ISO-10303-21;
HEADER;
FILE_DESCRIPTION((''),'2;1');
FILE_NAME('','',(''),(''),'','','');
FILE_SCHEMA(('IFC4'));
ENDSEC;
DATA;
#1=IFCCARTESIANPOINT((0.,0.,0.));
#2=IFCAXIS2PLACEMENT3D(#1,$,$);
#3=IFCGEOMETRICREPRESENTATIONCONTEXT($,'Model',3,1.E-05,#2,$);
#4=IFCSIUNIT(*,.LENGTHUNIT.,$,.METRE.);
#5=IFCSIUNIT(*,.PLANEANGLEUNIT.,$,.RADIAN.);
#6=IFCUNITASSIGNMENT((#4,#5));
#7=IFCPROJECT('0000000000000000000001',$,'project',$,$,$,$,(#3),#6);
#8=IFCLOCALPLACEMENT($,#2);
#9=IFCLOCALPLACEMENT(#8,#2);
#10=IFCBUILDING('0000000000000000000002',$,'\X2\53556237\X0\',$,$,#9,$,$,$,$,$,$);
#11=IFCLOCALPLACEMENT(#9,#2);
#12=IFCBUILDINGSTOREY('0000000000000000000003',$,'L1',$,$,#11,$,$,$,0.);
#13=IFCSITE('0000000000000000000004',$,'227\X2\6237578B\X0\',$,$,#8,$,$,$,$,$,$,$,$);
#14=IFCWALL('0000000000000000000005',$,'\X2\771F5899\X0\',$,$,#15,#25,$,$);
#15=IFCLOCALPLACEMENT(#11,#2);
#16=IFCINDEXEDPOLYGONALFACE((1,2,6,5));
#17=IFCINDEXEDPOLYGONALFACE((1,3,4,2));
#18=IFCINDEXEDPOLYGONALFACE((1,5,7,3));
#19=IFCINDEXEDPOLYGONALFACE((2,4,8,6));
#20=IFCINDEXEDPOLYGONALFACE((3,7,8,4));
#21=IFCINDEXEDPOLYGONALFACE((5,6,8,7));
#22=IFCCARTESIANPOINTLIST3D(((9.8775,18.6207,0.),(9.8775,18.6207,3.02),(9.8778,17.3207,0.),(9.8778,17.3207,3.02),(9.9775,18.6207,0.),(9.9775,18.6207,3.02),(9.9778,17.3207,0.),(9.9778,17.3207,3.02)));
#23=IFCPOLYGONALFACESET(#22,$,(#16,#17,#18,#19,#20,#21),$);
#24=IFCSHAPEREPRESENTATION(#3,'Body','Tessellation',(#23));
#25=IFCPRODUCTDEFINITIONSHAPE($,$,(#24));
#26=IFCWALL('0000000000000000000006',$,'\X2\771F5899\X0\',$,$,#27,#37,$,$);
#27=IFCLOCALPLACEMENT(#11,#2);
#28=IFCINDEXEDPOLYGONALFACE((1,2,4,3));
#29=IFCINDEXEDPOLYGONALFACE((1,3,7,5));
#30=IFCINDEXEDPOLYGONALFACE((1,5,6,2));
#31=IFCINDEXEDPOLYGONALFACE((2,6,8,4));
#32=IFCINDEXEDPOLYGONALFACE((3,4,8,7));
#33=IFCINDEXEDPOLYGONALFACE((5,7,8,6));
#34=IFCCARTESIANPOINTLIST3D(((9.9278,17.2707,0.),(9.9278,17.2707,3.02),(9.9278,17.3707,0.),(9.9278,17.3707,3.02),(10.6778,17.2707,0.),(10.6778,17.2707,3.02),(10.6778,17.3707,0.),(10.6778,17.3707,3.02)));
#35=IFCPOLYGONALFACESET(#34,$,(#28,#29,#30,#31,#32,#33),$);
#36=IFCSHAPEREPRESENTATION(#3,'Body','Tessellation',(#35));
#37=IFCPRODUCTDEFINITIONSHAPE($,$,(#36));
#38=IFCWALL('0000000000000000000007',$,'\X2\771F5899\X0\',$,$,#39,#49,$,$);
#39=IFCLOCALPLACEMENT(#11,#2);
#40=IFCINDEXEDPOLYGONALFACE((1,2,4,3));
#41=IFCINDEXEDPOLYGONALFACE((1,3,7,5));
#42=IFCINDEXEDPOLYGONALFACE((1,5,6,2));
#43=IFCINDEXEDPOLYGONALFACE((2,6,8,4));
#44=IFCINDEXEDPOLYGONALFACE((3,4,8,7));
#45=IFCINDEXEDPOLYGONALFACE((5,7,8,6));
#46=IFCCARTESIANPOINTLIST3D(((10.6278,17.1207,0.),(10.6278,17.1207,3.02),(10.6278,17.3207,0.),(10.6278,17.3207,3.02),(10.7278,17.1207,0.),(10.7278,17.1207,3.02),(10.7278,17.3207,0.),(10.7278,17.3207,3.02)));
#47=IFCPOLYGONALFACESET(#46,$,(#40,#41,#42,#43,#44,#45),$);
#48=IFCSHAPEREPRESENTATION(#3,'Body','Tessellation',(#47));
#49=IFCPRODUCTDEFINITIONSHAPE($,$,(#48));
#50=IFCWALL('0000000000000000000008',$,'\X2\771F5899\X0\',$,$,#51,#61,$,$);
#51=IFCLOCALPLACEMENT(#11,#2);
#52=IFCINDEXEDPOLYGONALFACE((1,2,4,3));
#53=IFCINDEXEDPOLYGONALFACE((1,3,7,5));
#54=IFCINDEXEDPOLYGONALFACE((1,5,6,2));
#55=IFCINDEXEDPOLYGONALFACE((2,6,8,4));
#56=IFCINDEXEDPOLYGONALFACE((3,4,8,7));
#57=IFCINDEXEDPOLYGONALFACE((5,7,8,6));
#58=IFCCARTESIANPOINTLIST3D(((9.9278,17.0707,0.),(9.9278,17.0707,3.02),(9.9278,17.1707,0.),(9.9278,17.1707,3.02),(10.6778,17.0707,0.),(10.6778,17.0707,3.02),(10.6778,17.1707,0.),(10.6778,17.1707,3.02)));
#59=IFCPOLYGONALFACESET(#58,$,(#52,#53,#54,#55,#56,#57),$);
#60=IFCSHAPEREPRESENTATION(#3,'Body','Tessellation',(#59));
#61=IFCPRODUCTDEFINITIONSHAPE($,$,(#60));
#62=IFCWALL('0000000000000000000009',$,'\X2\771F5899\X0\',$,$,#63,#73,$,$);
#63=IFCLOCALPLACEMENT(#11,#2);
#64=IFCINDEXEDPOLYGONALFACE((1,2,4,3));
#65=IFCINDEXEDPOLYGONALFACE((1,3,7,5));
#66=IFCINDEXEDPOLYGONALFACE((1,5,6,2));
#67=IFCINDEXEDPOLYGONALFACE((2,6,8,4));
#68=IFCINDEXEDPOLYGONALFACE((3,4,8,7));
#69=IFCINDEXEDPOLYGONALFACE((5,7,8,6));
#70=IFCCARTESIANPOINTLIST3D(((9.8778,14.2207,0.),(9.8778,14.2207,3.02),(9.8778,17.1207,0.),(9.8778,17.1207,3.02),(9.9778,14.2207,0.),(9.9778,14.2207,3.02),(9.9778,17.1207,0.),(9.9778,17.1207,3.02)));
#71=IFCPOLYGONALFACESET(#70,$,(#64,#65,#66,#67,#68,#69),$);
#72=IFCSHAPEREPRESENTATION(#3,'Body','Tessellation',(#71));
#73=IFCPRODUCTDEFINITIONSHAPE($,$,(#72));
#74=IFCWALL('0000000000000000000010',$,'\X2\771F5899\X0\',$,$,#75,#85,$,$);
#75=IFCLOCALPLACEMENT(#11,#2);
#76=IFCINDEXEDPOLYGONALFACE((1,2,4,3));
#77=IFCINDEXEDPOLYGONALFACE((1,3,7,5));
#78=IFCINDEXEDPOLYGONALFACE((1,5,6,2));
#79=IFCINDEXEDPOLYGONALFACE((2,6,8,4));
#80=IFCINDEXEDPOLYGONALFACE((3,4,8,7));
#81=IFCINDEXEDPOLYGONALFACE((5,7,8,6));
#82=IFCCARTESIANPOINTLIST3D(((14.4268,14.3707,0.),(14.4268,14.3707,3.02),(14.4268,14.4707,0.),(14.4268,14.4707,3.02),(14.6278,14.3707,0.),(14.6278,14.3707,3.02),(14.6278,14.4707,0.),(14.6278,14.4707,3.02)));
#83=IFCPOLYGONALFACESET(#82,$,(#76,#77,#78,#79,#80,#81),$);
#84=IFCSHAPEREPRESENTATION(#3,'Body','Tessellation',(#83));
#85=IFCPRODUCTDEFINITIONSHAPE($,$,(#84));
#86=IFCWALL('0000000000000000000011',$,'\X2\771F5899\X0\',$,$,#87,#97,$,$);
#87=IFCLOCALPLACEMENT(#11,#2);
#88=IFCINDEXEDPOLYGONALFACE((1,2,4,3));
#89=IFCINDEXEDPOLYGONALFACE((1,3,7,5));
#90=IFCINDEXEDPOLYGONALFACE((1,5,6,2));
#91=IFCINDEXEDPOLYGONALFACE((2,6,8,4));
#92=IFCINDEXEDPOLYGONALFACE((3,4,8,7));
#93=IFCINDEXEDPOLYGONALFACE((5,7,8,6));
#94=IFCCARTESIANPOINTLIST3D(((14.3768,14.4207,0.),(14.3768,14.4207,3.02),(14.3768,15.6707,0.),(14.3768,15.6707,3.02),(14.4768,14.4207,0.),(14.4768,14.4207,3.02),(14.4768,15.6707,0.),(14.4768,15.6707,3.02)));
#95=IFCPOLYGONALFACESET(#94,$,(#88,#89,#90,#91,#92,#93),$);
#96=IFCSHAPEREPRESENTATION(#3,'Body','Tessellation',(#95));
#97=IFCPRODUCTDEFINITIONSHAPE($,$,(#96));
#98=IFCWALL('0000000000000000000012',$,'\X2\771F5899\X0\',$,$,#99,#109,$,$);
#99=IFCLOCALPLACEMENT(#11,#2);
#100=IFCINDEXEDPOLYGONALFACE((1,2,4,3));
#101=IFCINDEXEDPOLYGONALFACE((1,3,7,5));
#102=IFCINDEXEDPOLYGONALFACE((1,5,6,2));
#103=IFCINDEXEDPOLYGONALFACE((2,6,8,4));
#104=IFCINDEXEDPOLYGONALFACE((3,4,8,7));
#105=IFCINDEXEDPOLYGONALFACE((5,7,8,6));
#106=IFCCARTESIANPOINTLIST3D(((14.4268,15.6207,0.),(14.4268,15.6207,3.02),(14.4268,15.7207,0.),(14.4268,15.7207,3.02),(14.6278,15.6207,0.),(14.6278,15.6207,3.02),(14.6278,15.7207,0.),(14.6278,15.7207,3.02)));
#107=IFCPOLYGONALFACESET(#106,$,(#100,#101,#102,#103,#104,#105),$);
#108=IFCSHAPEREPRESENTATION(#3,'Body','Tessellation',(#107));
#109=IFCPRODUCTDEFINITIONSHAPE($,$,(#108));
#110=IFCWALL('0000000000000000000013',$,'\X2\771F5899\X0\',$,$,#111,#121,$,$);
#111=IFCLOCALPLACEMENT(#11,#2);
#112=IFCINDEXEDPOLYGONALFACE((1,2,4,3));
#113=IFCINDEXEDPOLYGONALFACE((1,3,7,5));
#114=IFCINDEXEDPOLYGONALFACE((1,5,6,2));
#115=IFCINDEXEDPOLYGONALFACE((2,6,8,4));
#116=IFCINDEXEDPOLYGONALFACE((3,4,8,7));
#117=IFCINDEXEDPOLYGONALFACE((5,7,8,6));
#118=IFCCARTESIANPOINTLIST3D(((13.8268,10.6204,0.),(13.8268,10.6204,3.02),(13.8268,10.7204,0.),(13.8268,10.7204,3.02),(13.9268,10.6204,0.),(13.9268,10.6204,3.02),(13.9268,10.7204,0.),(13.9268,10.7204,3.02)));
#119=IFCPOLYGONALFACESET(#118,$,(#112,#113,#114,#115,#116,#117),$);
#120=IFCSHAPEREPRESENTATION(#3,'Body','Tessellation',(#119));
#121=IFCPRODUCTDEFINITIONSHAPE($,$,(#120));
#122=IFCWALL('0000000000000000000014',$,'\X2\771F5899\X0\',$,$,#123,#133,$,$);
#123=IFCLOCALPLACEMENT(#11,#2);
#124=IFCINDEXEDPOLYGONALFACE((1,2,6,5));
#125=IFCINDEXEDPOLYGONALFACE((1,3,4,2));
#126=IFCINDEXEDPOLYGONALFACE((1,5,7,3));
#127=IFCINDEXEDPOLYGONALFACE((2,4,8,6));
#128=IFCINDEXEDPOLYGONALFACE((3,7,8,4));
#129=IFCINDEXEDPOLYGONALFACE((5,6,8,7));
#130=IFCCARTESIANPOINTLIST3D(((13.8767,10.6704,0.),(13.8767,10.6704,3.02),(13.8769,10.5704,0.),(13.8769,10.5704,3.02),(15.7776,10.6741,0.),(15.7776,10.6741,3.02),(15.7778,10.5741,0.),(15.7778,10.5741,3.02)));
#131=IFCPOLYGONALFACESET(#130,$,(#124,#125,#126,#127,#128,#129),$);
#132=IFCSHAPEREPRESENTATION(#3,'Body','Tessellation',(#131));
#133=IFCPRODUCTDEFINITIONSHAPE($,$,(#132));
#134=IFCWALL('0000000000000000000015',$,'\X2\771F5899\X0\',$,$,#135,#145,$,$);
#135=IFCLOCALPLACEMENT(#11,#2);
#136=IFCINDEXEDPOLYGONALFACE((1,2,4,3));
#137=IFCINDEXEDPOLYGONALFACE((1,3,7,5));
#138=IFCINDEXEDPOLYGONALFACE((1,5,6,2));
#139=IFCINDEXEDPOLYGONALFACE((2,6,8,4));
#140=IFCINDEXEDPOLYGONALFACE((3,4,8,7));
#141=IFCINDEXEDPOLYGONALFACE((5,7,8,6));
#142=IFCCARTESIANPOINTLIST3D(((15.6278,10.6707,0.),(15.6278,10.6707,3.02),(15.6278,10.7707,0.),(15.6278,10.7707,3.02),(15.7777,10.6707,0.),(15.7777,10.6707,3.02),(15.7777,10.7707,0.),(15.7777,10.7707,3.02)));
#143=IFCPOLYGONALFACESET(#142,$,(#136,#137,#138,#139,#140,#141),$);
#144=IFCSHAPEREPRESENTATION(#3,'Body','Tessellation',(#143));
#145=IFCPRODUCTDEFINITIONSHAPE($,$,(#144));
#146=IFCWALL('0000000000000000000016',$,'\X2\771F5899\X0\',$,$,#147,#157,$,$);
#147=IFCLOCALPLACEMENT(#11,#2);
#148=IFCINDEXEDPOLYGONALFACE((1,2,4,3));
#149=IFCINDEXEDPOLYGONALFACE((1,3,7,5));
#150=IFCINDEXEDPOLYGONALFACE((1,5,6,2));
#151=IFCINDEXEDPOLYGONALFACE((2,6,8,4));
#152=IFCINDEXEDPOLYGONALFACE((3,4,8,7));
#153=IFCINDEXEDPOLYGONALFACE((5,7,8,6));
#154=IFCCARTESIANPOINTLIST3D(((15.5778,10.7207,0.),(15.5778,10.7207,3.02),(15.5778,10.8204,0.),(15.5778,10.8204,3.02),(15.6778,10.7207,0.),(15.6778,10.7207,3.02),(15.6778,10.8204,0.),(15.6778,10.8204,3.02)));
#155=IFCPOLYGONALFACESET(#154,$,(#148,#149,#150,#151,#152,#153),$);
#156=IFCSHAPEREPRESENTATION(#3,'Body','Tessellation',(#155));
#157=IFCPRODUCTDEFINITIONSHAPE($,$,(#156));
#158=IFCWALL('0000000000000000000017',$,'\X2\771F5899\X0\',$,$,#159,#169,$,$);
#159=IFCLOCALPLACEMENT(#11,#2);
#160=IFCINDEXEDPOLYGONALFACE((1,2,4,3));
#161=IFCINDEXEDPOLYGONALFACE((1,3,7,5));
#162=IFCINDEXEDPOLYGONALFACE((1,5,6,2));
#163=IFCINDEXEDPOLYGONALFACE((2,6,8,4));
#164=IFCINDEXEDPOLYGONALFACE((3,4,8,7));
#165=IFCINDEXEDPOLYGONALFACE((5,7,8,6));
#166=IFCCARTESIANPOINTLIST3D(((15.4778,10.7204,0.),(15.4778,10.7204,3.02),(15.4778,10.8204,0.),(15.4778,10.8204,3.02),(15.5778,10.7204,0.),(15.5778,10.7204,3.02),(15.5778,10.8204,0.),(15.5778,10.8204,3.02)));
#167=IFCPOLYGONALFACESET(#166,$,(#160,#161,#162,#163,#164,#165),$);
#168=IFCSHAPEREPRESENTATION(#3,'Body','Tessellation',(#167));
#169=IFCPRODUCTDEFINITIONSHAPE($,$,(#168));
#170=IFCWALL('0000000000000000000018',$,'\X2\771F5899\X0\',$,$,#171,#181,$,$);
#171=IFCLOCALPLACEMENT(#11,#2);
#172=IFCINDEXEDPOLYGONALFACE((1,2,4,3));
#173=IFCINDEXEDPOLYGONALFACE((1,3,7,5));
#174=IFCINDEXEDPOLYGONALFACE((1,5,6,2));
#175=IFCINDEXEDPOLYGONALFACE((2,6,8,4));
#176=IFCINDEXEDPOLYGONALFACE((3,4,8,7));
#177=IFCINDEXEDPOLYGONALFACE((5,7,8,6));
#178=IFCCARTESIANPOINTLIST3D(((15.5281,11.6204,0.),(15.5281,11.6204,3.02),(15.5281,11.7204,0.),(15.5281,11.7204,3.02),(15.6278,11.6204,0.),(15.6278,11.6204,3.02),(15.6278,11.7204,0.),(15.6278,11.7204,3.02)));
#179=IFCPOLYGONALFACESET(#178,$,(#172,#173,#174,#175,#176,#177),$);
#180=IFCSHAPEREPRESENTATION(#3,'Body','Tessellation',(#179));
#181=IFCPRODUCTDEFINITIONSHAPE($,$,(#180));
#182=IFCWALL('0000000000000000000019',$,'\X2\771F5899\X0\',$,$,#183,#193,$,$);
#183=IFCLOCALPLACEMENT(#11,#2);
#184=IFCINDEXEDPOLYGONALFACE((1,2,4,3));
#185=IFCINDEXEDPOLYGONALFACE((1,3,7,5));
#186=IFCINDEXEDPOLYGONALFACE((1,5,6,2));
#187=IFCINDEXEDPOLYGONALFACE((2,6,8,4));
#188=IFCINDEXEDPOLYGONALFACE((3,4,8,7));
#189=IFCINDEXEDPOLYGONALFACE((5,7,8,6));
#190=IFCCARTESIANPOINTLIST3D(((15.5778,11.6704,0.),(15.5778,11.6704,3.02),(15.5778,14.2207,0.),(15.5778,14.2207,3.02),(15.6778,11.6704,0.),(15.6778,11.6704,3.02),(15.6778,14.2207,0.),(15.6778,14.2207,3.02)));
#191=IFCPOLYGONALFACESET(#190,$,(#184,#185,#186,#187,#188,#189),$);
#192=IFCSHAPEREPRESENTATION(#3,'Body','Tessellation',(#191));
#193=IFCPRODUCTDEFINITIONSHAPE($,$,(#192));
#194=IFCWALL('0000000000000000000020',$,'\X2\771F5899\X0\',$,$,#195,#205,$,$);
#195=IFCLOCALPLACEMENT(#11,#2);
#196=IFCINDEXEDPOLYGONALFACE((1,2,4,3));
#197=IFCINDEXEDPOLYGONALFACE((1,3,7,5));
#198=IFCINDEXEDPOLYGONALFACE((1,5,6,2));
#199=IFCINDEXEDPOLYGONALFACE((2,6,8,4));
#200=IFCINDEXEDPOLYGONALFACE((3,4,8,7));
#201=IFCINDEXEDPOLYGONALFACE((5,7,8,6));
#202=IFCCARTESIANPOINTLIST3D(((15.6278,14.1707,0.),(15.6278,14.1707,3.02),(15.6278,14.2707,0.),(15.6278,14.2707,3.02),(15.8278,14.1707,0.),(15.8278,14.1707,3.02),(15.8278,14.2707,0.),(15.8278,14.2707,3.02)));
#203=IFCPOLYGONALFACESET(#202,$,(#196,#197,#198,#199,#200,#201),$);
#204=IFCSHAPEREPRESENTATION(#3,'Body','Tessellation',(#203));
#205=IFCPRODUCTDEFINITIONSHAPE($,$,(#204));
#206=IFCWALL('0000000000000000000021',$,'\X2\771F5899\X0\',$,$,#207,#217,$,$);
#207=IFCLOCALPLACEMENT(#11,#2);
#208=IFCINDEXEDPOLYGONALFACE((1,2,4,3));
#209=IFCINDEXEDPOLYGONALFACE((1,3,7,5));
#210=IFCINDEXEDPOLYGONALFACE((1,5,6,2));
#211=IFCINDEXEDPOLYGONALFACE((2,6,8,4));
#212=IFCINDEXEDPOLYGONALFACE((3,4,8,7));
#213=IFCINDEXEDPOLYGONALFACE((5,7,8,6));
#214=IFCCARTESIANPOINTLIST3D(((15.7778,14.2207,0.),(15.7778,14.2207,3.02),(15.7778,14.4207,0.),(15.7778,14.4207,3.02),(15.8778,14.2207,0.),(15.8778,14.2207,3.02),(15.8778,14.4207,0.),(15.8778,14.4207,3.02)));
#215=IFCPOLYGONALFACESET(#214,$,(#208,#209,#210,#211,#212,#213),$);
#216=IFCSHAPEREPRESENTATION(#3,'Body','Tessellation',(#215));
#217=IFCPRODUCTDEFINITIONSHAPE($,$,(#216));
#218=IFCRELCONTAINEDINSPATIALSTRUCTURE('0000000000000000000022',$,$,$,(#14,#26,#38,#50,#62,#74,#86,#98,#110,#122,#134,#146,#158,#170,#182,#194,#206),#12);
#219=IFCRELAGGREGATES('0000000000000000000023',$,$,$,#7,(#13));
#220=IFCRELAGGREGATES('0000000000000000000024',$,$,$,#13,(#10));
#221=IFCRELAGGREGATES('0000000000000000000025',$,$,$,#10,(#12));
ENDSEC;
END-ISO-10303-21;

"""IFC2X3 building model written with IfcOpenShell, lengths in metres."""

from ifc_helpers import new_model, si_unit, origin, place, context, project, spatial, polyline, outline, extrude, element, save


model = new_model("IFC2X3")

# Units and contexts
model_context = context("Model", 3, precision=1e-05, world=origin())
ifc_project = project(units=[si_unit("LENGTHUNIT", "METRE"), si_unit("PLANEANGLEUNIT", "RADIAN")], contexts=[model_context])

# Site, building, storey
site_placement = place(None, origin())
site = spatial("IfcSite", under=ifc_project, at=site_placement, Name="227户型")
building_placement = place(site_placement, origin())
building = spatial("IfcBuilding", under=site, at=building_placement, Name="单户")
storey_placement = place(building_placement, origin())
storey = spatial("IfcBuildingStorey", under=building, at=storey_placement, Name="L1", Elevation=0.0)

# Walls
wall_1_placement = place(storey_placement, origin())
element("IfcWall", 1, at=wall_1_placement, inside=storey, Name="真墙", context=model_context, shape_type="SweptSolid", body=[
    extrude(outline(polyline([(9.9775, 18.6207), (9.9778, 17.3207), (9.8778, 17.3207), (9.8775, 18.6207), (9.9775, 18.6207)])), origin(), (0.0, 0.0, 1.0), 3.02),
])
wall_2_placement = place(storey_placement, origin())
element("IfcWall", 2, at=wall_2_placement, inside=storey, Name="真墙", context=model_context, shape_type="SweptSolid", body=[
    extrude(outline(polyline([(9.9278, 17.3707), (10.6778, 17.3707), (10.6778, 17.2707), (9.9278, 17.2707), (9.9278, 17.3707)])), origin(), (0.0, 0.0, 1.0), 3.02),
])
wall_3_placement = place(storey_placement, origin())
element("IfcWall", 3, at=wall_3_placement, inside=storey, Name="真墙", context=model_context, shape_type="SweptSolid", body=[
    extrude(outline(polyline([(10.7278, 17.3207), (10.7278, 17.1207), (10.6278, 17.1207), (10.6278, 17.3207), (10.7278, 17.3207)])), origin(), (0.0, 0.0, 1.0), 3.02),
])
wall_4_placement = place(storey_placement, origin())
element("IfcWall", 4, at=wall_4_placement, inside=storey, Name="真墙", context=model_context, shape_type="SweptSolid", body=[
    extrude(outline(polyline([(10.6778, 17.0707), (9.9278, 17.0707), (9.9278, 17.1707), (10.6778, 17.1707), (10.6778, 17.0707)])), origin(), (0.0, 0.0, 1.0), 3.02),
])
wall_5_placement = place(storey_placement, origin())
element("IfcWall", 5, at=wall_5_placement, inside=storey, Name="真墙", context=model_context, shape_type="SweptSolid", body=[
    extrude(outline(polyline([(9.9778, 17.1207), (9.9778, 14.2207), (9.8778, 14.2207), (9.8778, 17.1207), (9.9778, 17.1207)])), origin(), (0.0, 0.0, 1.0), 3.02),
])
wall_6_placement = place(storey_placement, origin())
element("IfcWall", 6, at=wall_6_placement, inside=storey, Name="真墙", context=model_context, shape_type="SweptSolid", body=[
    extrude(outline(polyline([(14.6278, 14.3707), (14.4268, 14.3707), (14.4268, 14.4707), (14.6278, 14.4707), (14.6278, 14.3707)])), origin(), (0.0, 0.0, 1.0), 3.02),
])
wall_7_placement = place(storey_placement, origin())
element("IfcWall", 7, at=wall_7_placement, inside=storey, Name="真墙", context=model_context, shape_type="SweptSolid", body=[
    extrude(outline(polyline([(14.3768, 14.4207), (14.3768, 15.6707), (14.4768, 15.6707), (14.4768, 14.4207), (14.3768, 14.4207)])), origin(), (0.0, 0.0, 1.0), 3.02),
])
wall_8_placement = place(storey_placement, origin())
element("IfcWall", 8, at=wall_8_placement, inside=storey, Name="真墙", context=model_context, shape_type="SweptSolid", body=[
    extrude(outline(polyline([(14.4268, 15.7207), (14.6278, 15.7207), (14.6278, 15.6207), (14.4268, 15.6207), (14.4268, 15.7207)])), origin(), (0.0, 0.0, 1.0), 3.02),
])
wall_9_placement = place(storey_placement, origin())
element("IfcWall", 9, at=wall_9_placement, inside=storey, Name="真墙", context=model_context, shape_type="SweptSolid", body=[
    extrude(outline(polyline([(13.9268, 10.7204), (13.9268, 10.6204), (13.8268, 10.6204), (13.8268, 10.7204), (13.9268, 10.7204)])), origin(), (0.0, 0.0, 1.0), 3.02),
])
wall_10_placement = place(storey_placement, origin())
element("IfcWall", 10, at=wall_10_placement, inside=storey, Name="真墙", context=model_context, shape_type="SweptSolid", body=[
    extrude(outline(polyline([(13.8767, 10.6704), (15.7776, 10.6741), (15.7778, 10.5741), (13.8769, 10.5704), (13.8767, 10.6704)])), origin(), (0.0, 0.0, 1.0), 3.02),
])

# Walls
wall_11_placement = place(storey_placement, origin())
element("IfcWall", 11, at=wall_11_placement, inside=storey, Name="真墙", context=model_context, shape_type="SweptSolid", body=[
    extrude(outline(polyline([(15.7777, 10.6707), (15.6278, 10.6707), (15.6278, 10.7707), (15.7777, 10.7707), (15.7777, 10.6707)])), origin(), (0.0, 0.0, 1.0), 3.02),
])
wall_12_placement = place(storey_placement, origin())
element("IfcWall", 12, at=wall_12_placement, inside=storey, Name="真墙", context=model_context, shape_type="SweptSolid", body=[
    extrude(outline(polyline([(15.5778, 10.7207), (15.5778, 10.8204), (15.6778, 10.8204), (15.6778, 10.7207), (15.5778, 10.7207)])), origin(), (0.0, 0.0, 1.0), 3.02),
])

# Walls
wall_13_placement = place(storey_placement, origin())
element("IfcWall", 13, at=wall_13_placement, inside=storey, Name="真墙", context=model_context, shape_type="SweptSolid", body=[
    extrude(outline(polyline([(15.5778, 10.8204), (15.5778, 10.7204), (15.4778, 10.7204), (15.4778, 10.8204), (15.5778, 10.8204)])), origin(), (0.0, 0.0, 1.0), 3.02),
])
wall_14_placement = place(storey_placement, origin())
element("IfcWall", 14, at=wall_14_placement, inside=storey, Name="真墙", context=model_context, shape_type="SweptSolid", body=[
    extrude(outline(polyline([(15.5281, 11.7204), (15.6278, 11.7204), (15.6278, 11.6204), (15.5281, 11.6204), (15.5281, 11.7204)])), origin(), (0.0, 0.0, 1.0), 3.02),
])
wall_15_placement = place(storey_placement, origin())
element("IfcWall", 15, at=wall_15_placement, inside=storey, Name="真墙", context=model_context, shape_type="SweptSolid", body=[
    extrude(outline(polyline([(15.5778, 11.6704), (15.5778, 14.2207), (15.6778, 14.2207), (15.6778, 11.6704), (15.5778, 11.6704)])), origin(), (0.0, 0.0, 1.0), 3.02),
])
wall_16_placement = place(storey_placement, origin())
element("IfcWall", 16, at=wall_16_placement, inside=storey, Name="真墙", context=model_context, shape_type="SweptSolid", body=[
    extrude(outline(polyline([(15.6278, 14.2707), (15.8278, 14.2707), (15.8278, 14.1707), (15.6278, 14.1707), (15.6278, 14.2707)])), origin(), (0.0, 0.0, 1.0), 3.02),
])
wall_17_placement = place(storey_placement, origin())
element("IfcWall", 17, at=wall_17_placement, inside=storey, Name="真墙", context=model_context, shape_type="SweptSolid", body=[
    extrude(outline(polyline([(15.7778, 14.2207), (15.7778, 14.4207), (15.8778, 14.4207), (15.8778, 14.2207), (15.7778, 14.2207)])), origin(), (0.0, 0.0, 1.0), 3.02),
])

save(model, "model.ifc")
